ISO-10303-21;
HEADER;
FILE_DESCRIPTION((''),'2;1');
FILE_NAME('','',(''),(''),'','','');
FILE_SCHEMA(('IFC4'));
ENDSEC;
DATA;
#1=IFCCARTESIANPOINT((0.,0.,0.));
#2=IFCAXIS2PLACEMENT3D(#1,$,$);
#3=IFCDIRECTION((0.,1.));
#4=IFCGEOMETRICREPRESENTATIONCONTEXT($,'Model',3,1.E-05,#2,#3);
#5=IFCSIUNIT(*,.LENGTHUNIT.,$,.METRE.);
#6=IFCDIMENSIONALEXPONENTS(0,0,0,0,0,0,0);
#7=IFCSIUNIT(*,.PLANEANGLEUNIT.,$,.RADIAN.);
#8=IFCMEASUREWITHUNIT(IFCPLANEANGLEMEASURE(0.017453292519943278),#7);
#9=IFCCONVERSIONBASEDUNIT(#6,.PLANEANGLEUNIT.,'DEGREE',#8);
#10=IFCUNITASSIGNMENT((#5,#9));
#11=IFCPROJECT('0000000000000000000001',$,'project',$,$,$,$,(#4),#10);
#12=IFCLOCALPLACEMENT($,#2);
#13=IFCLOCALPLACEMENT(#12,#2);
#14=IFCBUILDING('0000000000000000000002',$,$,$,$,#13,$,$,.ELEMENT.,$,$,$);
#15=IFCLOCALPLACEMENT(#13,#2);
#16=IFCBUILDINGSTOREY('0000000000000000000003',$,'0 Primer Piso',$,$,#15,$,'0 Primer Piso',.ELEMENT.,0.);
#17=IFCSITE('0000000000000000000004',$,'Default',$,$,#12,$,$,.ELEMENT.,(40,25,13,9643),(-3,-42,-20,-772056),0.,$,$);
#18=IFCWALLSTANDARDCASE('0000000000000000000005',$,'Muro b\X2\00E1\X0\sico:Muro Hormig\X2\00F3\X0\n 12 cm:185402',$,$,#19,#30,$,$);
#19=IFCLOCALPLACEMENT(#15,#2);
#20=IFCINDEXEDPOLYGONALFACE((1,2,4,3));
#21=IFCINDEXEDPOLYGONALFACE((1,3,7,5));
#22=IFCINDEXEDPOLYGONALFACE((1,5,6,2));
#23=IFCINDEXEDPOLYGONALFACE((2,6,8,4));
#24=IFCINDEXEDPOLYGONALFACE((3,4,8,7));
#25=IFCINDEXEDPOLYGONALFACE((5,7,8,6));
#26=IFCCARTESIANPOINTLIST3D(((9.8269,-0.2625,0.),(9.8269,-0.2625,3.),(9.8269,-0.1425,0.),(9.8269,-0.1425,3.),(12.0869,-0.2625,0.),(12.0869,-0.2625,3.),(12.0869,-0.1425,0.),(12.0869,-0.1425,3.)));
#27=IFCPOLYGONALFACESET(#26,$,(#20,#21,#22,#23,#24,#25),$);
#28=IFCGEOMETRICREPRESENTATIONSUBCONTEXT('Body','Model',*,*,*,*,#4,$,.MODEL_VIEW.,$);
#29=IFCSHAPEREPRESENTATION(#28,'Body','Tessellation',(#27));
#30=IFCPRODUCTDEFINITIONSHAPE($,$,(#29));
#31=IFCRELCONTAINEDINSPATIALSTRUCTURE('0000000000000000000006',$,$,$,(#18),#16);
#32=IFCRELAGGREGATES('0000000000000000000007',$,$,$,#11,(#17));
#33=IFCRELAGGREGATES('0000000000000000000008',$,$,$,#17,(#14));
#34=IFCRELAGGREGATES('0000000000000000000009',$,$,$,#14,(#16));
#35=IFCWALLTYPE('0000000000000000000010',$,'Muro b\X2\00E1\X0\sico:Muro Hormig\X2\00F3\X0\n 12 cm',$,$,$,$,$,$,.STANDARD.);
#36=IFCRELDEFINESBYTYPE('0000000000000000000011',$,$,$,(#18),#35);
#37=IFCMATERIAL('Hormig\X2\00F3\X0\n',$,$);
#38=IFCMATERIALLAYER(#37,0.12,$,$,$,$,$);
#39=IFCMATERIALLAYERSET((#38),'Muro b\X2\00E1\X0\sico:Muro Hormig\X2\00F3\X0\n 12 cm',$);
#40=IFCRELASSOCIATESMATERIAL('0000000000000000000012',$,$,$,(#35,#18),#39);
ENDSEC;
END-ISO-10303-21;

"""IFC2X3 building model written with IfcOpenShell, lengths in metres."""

from ifc_helpers import new_model, entity, si_unit, converted_unit, direction, frame, frame_2d, origin, place, context, subcontext, project, spatial, rectangle, extrude, material, layer, layer_set, layer_usage, type_object, element, save


model = new_model("IFC2X3")

# Units and contexts
model_context = context("Model", 3, precision=1e-05, world=origin(), true_north=direction((0.0, 1.0)))
body_context = subcontext(model_context, "Body", "Model", "MODEL_VIEW")
ifc_project = project(units=[si_unit("LENGTHUNIT", "METRE"), converted_unit("PLANEANGLEUNIT", "DEGREE", entity("IfcPlaneAngleMeasure", 0.017453292519943278), si_unit("PLANEANGLEUNIT", "RADIAN"), dimensions=[0, 0, 0, 0, 0, 0, 0])], contexts=[model_context])

# Site, building, storey
site_placement = place(None, origin())
site = spatial("IfcSite", under=ifc_project, at=site_placement, Name="Default", CompositionType="ELEMENT", RefLatitude=(40, 25, 13, 9643), RefLongitude=(-3, -42, -20, -772056), RefElevation=0.0)
building_placement = place(site_placement, origin())
building = spatial("IfcBuilding", under=site, at=building_placement, CompositionType="ELEMENT")
storey_placement = place(building_placement, origin())
storey = spatial("IfcBuildingStorey", under=building, at=storey_placement, Name="0 Primer Piso", LongName="0 Primer Piso", CompositionType="ELEMENT", Elevation=0.0)

# Shared definitions
ifc_material = material(Name="Hormigón")
ifc_layer = layer(ifc_material, 0.12)
ifc_layer_set = layer_set([ifc_layer], Name="Muro básico:Muro Hormigón 12 cm")
wall_type = type_object("IfcWallType", Name="Muro básico:Muro Hormigón 12 cm", PredefinedType="STANDARD", material=ifc_layer_set)

# Wall
ifc_layer_usage_1 = layer_usage(ifc_layer_set, "AXIS2", "NEGATIVE", 0.06)
wall_1_placement = place(storey_placement, frame((9.8269, -0.2025, 0.0)))
element("IfcWallStandardCase", 1, at=wall_1_placement, inside=storey, type_object=wall_type, material=ifc_layer_usage_1, Name="Muro básico:Muro Hormigón 12 cm:185402", context=body_context, shape_type="SweptSolid", body=[
    extrude(rectangle(XDim=2.26, YDim=0.12, at=frame_2d((1.13, 0.0), x_axis=(-1.0, 0.0))), origin(), (0.0, 0.0, 1.0), 3.0),
])

save(model, "model.ifc")
